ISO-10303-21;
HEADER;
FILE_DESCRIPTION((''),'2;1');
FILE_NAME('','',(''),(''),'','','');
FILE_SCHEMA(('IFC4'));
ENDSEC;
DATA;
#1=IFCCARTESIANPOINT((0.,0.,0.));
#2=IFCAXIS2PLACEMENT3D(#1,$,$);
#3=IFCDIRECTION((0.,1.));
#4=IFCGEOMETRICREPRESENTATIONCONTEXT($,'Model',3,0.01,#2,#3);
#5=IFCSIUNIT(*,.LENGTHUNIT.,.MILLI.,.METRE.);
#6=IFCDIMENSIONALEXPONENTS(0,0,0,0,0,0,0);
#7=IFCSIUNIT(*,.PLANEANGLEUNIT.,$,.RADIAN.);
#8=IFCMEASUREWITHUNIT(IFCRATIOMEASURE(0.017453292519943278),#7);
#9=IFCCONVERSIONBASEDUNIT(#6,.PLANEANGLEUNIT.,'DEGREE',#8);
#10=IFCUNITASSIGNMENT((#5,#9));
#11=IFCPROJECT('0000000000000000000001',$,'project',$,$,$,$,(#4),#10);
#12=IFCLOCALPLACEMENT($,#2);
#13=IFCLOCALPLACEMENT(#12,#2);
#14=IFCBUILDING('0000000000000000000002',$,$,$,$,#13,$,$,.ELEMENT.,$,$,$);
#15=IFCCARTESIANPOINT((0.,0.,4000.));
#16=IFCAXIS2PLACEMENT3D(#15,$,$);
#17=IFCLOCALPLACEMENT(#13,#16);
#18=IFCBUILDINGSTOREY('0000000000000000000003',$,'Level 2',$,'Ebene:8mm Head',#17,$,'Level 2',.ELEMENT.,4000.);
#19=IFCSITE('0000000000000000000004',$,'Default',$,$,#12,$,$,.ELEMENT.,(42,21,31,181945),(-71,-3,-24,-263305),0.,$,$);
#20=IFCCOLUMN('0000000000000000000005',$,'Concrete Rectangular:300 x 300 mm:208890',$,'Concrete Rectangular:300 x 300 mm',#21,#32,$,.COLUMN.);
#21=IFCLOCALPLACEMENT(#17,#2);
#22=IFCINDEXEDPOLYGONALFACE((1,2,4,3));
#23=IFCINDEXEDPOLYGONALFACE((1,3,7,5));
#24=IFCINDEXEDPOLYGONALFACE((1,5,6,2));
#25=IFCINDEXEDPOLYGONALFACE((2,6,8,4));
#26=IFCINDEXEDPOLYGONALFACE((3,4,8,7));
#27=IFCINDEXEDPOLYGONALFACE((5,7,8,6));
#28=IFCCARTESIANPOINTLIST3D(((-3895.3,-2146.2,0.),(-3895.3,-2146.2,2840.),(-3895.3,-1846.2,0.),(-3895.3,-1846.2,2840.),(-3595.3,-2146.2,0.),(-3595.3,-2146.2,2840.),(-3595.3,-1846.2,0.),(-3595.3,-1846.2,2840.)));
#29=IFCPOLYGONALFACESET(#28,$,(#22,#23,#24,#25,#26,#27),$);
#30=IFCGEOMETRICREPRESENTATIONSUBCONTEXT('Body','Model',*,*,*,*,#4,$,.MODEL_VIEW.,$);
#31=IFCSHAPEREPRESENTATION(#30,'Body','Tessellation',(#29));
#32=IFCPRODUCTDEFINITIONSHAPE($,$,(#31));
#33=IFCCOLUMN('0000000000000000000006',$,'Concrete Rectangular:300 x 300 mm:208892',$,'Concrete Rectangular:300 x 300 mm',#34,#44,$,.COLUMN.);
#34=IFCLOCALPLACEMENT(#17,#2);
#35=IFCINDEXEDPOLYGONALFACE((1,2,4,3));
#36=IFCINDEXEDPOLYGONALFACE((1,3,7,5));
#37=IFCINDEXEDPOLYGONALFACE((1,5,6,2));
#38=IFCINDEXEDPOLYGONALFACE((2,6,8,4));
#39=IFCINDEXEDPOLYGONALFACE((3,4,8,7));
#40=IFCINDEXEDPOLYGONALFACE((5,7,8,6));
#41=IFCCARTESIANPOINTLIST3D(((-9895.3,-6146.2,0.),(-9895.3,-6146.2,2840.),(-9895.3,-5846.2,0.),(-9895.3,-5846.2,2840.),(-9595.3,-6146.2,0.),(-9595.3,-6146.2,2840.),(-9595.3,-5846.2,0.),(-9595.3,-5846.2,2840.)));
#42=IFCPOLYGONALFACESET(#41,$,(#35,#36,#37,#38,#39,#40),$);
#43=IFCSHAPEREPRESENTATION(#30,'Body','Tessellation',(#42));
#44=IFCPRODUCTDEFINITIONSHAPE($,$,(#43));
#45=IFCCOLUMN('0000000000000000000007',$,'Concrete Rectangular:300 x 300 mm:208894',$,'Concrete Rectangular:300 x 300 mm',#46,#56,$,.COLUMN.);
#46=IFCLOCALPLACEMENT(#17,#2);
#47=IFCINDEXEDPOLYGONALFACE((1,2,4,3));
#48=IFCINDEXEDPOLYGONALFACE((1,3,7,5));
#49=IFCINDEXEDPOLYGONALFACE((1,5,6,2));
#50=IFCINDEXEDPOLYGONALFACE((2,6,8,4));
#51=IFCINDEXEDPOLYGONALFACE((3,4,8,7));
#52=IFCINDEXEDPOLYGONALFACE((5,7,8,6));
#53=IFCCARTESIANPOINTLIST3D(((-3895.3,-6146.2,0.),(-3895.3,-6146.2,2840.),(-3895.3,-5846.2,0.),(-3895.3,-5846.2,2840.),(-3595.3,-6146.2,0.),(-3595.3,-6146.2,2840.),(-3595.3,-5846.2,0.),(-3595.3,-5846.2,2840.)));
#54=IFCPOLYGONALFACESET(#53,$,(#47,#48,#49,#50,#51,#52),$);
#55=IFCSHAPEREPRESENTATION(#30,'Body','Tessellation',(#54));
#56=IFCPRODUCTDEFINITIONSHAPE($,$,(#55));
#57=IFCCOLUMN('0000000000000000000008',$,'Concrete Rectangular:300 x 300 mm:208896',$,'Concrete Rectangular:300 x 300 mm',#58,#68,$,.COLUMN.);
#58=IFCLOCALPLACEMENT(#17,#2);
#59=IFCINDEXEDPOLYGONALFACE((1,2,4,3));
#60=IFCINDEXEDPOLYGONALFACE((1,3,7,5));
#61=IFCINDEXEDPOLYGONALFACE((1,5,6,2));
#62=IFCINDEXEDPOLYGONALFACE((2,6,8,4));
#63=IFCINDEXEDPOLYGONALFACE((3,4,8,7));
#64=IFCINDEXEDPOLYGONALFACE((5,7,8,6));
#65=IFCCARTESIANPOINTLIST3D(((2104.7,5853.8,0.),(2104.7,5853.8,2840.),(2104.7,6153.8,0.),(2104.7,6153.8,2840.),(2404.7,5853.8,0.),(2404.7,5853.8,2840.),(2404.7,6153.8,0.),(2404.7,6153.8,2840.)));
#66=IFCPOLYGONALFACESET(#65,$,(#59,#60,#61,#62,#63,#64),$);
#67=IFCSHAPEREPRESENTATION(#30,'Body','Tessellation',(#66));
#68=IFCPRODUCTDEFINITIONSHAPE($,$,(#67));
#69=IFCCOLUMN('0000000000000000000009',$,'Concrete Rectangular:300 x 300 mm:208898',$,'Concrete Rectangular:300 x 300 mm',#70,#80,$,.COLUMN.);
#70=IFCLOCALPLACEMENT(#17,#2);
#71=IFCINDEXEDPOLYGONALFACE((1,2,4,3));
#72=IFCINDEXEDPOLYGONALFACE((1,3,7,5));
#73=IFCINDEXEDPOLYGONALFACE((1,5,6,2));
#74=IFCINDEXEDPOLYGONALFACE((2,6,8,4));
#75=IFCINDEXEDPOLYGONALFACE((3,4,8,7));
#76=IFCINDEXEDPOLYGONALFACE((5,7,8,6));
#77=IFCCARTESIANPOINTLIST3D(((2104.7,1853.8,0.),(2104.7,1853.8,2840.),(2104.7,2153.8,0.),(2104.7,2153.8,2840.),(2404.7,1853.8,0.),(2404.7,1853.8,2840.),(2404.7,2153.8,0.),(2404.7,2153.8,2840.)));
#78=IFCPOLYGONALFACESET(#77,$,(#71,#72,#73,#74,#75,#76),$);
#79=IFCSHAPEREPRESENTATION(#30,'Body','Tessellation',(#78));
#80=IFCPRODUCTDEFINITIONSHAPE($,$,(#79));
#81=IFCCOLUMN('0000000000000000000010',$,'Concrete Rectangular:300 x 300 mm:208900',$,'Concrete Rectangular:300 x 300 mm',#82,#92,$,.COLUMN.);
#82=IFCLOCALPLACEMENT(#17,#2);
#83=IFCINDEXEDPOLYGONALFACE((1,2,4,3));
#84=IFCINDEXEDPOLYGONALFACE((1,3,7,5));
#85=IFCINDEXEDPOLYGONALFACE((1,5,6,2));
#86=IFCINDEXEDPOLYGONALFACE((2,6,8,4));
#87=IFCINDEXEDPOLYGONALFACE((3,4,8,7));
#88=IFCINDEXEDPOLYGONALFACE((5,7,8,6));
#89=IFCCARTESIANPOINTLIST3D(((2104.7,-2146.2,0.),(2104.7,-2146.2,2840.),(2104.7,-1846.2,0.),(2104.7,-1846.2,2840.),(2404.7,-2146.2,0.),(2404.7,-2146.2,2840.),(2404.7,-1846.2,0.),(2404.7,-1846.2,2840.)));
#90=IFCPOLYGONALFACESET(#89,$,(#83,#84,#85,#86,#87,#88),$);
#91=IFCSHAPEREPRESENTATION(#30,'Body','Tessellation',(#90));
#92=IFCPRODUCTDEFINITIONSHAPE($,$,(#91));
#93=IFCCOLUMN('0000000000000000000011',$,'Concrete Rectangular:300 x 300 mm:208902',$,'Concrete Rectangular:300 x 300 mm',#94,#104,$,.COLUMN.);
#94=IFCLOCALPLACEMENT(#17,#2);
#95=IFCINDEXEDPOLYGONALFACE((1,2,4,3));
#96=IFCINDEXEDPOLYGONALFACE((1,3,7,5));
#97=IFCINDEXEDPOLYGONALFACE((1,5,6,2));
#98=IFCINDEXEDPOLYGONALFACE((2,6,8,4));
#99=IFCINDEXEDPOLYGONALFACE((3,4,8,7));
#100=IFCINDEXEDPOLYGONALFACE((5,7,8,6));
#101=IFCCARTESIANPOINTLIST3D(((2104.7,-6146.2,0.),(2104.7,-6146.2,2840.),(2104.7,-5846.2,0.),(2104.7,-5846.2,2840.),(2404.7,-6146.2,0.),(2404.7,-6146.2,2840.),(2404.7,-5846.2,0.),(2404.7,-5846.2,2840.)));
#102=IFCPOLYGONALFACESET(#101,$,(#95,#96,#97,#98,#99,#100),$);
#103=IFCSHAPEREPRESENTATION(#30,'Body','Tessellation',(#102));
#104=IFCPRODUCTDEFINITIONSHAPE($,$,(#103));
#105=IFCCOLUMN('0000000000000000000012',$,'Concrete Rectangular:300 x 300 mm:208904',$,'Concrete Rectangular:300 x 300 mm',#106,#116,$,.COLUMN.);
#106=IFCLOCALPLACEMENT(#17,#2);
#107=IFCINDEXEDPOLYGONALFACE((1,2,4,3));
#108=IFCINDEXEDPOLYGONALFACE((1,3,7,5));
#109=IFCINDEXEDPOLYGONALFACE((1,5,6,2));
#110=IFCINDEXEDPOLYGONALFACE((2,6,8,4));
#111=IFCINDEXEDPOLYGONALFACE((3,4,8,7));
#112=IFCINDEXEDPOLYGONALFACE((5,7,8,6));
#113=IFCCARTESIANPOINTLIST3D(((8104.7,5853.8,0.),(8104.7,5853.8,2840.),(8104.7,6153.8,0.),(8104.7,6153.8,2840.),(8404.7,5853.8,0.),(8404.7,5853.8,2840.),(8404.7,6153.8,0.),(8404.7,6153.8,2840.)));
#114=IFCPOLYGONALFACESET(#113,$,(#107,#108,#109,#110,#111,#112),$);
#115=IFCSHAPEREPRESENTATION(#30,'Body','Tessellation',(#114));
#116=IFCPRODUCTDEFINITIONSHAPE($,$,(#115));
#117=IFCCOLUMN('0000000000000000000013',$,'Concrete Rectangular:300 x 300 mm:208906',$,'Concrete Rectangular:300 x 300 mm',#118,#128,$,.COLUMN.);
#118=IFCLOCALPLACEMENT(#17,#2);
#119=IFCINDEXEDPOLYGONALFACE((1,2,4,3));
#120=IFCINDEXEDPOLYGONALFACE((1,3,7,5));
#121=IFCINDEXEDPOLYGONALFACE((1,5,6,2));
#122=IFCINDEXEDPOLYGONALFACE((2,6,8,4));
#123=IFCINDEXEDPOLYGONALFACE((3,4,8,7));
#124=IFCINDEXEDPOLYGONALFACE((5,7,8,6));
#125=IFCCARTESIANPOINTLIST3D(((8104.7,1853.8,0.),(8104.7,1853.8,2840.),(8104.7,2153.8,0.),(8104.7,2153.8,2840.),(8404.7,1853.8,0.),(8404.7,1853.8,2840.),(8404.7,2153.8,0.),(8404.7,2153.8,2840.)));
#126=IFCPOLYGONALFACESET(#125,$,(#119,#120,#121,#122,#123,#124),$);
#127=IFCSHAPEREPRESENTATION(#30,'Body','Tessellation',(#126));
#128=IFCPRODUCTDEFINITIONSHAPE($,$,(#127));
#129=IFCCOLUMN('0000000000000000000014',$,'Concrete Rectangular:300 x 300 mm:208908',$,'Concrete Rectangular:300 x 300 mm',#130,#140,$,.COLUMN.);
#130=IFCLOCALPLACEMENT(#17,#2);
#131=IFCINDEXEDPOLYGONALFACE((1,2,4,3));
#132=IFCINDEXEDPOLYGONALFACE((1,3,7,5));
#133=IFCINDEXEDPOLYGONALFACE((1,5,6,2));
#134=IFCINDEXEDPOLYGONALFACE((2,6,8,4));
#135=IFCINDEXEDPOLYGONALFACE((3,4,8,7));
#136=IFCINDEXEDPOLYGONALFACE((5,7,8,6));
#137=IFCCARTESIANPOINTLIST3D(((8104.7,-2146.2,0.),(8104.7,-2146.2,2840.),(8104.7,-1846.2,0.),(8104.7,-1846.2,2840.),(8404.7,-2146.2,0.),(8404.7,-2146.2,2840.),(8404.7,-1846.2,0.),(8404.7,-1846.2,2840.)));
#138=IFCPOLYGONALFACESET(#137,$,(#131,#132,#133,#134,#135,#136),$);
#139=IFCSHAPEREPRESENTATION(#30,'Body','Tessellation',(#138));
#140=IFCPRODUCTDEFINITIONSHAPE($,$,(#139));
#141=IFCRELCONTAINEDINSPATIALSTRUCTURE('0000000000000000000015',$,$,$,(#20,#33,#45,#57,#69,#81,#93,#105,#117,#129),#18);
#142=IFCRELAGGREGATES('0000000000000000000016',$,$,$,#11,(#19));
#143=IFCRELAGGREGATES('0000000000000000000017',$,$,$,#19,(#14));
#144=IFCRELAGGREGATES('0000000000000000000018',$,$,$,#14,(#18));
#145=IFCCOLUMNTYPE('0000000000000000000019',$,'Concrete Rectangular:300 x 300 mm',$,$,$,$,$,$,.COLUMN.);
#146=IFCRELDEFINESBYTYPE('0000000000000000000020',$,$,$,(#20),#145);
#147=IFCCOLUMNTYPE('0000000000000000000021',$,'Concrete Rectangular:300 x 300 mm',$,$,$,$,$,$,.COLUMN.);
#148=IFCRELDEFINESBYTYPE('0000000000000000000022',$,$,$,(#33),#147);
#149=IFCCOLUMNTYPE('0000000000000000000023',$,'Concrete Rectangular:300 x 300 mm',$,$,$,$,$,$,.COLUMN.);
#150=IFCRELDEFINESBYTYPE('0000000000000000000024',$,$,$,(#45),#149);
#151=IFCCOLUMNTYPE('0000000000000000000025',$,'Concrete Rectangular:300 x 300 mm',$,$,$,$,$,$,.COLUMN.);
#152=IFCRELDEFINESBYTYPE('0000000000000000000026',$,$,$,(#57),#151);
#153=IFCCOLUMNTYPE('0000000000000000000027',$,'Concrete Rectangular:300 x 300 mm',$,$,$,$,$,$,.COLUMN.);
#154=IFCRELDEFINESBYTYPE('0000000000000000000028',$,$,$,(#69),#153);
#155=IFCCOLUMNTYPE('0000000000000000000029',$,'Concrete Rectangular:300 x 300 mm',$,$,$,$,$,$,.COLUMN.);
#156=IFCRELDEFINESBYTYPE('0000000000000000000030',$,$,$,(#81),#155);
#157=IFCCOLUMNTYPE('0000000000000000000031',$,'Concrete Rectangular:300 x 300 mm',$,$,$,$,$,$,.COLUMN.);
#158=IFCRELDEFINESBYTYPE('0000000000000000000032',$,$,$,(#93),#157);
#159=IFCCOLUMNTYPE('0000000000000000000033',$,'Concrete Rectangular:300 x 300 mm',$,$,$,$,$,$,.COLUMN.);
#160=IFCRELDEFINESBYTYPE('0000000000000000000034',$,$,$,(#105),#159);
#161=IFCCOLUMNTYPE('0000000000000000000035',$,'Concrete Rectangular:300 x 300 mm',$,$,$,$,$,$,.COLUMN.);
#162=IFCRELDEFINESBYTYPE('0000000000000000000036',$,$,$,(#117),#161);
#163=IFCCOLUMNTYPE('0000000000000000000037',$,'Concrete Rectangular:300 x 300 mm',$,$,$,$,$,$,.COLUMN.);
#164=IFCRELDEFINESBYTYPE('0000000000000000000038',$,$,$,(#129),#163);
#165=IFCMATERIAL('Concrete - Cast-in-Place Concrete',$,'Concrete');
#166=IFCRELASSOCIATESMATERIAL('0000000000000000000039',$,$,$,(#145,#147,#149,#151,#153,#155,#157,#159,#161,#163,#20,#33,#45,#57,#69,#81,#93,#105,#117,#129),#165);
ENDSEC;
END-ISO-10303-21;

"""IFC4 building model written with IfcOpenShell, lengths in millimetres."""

from ifc_helpers import new_model, entity, si_unit, converted_unit, direction, frame, frame_2d, origin, origin_2d_with_axis, place, context, subcontext, project, spatial, polyline, segment, composite_curve, rectangle, outline, extrude, source, transform, mapped, material, material_profile, profile_set, profile_usage, type_object, type_shapes, element, save


model = new_model("IFC4")

# Units and contexts
model_context = context("Model", 3, precision=0.01, world=origin(), true_north=direction((0.0, 1.0)))
body_context = subcontext(model_context, "Body", "Model", "MODEL_VIEW")
ifc_project = project(units=[si_unit("LENGTHUNIT", "METRE", prefix="MILLI"), converted_unit("PLANEANGLEUNIT", "DEGREE", entity("IfcRatioMeasure", 0.017453292519943278), si_unit("PLANEANGLEUNIT", "RADIAN"), dimensions=[0, 0, 0, 0, 0, 0, 0])], contexts=[model_context])

# Site, building, storey
site_placement = place(None, origin())
site = spatial("IfcSite", under=ifc_project, at=site_placement, Name="Default", CompositionType="ELEMENT", RefLatitude=(42, 21, 31, 181945), RefLongitude=(-71, -3, -24, -263305), RefElevation=0.0)
building_placement = place(site_placement, origin())
building = spatial("IfcBuilding", under=site, at=building_placement, CompositionType="ELEMENT")
storey_placement = place(building_placement, frame((0.0, 0.0, 4000.0)))
storey = spatial("IfcBuildingStorey", under=building, at=storey_placement, Name="Level 2", ObjectType="Ebene:8mm Head", LongName="Level 2", CompositionType="ELEMENT", Elevation=4000.0)

# Columns
ifc_material_1 = material(Name="Concrete - Cast-in-Place Concrete", Category="Concrete")
ifc_material_profile_1 = material_profile(ifc_material_1, outline(composite_curve([segment(polyline([(150.0, 150.0, 0.0), (150.0, -150.0, 0.0)]), True, "CONTINUOUS"), segment(polyline([(150.0, -150.0, 0.0), (-150.0, -150.0, 0.0)]), True, "CONTINUOUS"), segment(polyline([(-150.0, -150.0, 0.0), (-150.0, 150.0, 0.0)]), True, "CONTINUOUS"), segment(polyline([(-150.0, 150.0, 0.0), (150.0, 150.0, 0.0)]), True, "CONTINUOUS")], self_intersect=False), kind="CURVE"), Name="300 x 300 mm")
ifc_material_profile_2 = material_profile(ifc_material_1, outline(composite_curve([segment(polyline([(150.0, 150.0, 4000.0), (-150.0, 150.0, 4000.0)]), True, "CONTINUOUS"), segment(polyline([(-150.0, 150.0, 4000.0), (-150.0, -150.0, 4000.0)]), True, "CONTINUOUS"), segment(polyline([(-150.0, -150.0, 4000.0), (150.0, -150.0, 4000.0)]), True, "CONTINUOUS"), segment(polyline([(150.0, -150.0, 4000.0), (150.0, 150.0, 4000.0)]), True, "CONTINUOUS")], self_intersect=False), kind="CURVE"), Name="300 x 300 mm")
ifc_profile_set = profile_set([ifc_material_profile_1, ifc_material_profile_2], Name="300 x 300 mm")
ifc_profile_usage_1 = profile_usage(ifc_profile_set)
column_type_1 = type_object("IfcColumnType", Name="Concrete Rectangular:300 x 300 mm", PredefinedType="COLUMN", material=ifc_profile_set)
shared_shape_1 = source(origin(), body_context, "Body", "SweptSolid", [
    extrude(rectangle(XDim=300.0, YDim=300.0, at=origin_2d_with_axis()), frame((-3745.3, -1996.2, 4000.0), z_axis=(0.0, 0.0, 1.0), x_axis=(0.0, -1.0, 0.0)), (0.0, 0.0, 1.0), 2840.0),
])
type_shapes(column_type_1, [shared_shape_1])
column_1_placement = place(storey_placement, frame((0.0, 0.0, -4000.0)))
element("IfcColumn", 1, at=column_1_placement, inside=storey, type_object=column_type_1, material=ifc_profile_usage_1, Name="Concrete Rectangular:300 x 300 mm:208890", ObjectType="Concrete Rectangular:300 x 300 mm", PredefinedType="COLUMN", context=body_context, shape_type="MappedRepresentation", body=[
    mapped(shared_shape_1, transform((0.0, 0.0, 0.0), scale=1.0)),
])
ifc_profile_usage_2 = profile_usage(ifc_profile_set)
column_type_2 = type_object("IfcColumnType", Name="Concrete Rectangular:300 x 300 mm", PredefinedType="COLUMN", material=ifc_profile_set)
shared_shape_2 = source(origin(), body_context, "Body", "SweptSolid", [
    extrude(rectangle(XDim=300.0, YDim=300.0, at=frame_2d((0.0, 0.0), x_axis=(1.0, 0.0))), frame((-9745.3, -5996.2, 4000.0), z_axis=(0.0, 0.0, 1.0), x_axis=(0.0, -1.0, 0.0)), (0.0, 0.0, 1.0), 2840.0),
])
type_shapes(column_type_2, [shared_shape_2])
column_2_placement = place(storey_placement, frame((0.0, 0.0, -4000.0)))
element("IfcColumn", 2, at=column_2_placement, inside=storey, type_object=column_type_2, material=ifc_profile_usage_2, Name="Concrete Rectangular:300 x 300 mm:208892", ObjectType="Concrete Rectangular:300 x 300 mm", PredefinedType="COLUMN", context=body_context, shape_type="MappedRepresentation", body=[
    mapped(shared_shape_2, transform((0.0, 0.0, 0.0), scale=1.0)),
])
ifc_profile_usage_3 = profile_usage(ifc_profile_set)
column_type_3 = type_object("IfcColumnType", Name="Concrete Rectangular:300 x 300 mm", PredefinedType="COLUMN", material=ifc_profile_set)
shared_shape_3 = source(origin(), body_context, "Body", "SweptSolid", [
    extrude(rectangle(XDim=300.0, YDim=300.0, at=frame_2d((0.0, 0.0), x_axis=(1.0, 0.0))), frame((-3745.3, -5996.2, 4000.0), z_axis=(0.0, 0.0, 1.0), x_axis=(0.0, -1.0, 0.0)), (0.0, 0.0, 1.0), 2840.0),
])
type_shapes(column_type_3, [shared_shape_3])
column_3_placement = place(storey_placement, frame((0.0, 0.0, -4000.0)))
element("IfcColumn", 3, at=column_3_placement, inside=storey, type_object=column_type_3, material=ifc_profile_usage_3, Name="Concrete Rectangular:300 x 300 mm:208894", ObjectType="Concrete Rectangular:300 x 300 mm", PredefinedType="COLUMN", context=body_context, shape_type="MappedRepresentation", body=[
    mapped(shared_shape_3, transform((0.0, 0.0, 0.0), scale=1.0)),
])
ifc_profile_usage_4 = profile_usage(ifc_profile_set)
column_type_4 = type_object("IfcColumnType", Name="Concrete Rectangular:300 x 300 mm", PredefinedType="COLUMN", material=ifc_profile_set)
shared_shape_4 = source(origin(), body_context, "Body", "SweptSolid", [
    extrude(rectangle(XDim=300.0, YDim=300.0, at=frame_2d((0.0, 0.0), x_axis=(1.0, 0.0))), frame((2254.7, 6003.8, 4000.0), z_axis=(0.0, 0.0, 1.0), x_axis=(0.0, -1.0, 0.0)), (0.0, 0.0, 1.0), 2840.0),
])
type_shapes(column_type_4, [shared_shape_4])
column_4_placement = place(storey_placement, frame((0.0, 0.0, -4000.0)))
element("IfcColumn", 4, at=column_4_placement, inside=storey, type_object=column_type_4, material=ifc_profile_usage_4, Name="Concrete Rectangular:300 x 300 mm:208896", ObjectType="Concrete Rectangular:300 x 300 mm", PredefinedType="COLUMN", context=body_context, shape_type="MappedRepresentation", body=[
    mapped(shared_shape_4, transform((0.0, 0.0, 0.0), scale=1.0)),
])
ifc_profile_usage_5 = profile_usage(ifc_profile_set)
column_type_5 = type_object("IfcColumnType", Name="Concrete Rectangular:300 x 300 mm", PredefinedType="COLUMN", material=ifc_profile_set)
shared_shape_5 = source(origin(), body_context, "Body", "SweptSolid", [
    extrude(rectangle(XDim=300.0, YDim=300.0, at=origin_2d_with_axis()), frame((2254.7, 2003.8, 4000.0), z_axis=(0.0, 0.0, 1.0), x_axis=(0.0, -1.0, 0.0)), (0.0, 0.0, 1.0), 2840.0),
])
type_shapes(column_type_5, [shared_shape_5])
column_5_placement = place(storey_placement, frame((0.0, 0.0, -4000.0)))
element("IfcColumn", 5, at=column_5_placement, inside=storey, type_object=column_type_5, material=ifc_profile_usage_5, Name="Concrete Rectangular:300 x 300 mm:208898", ObjectType="Concrete Rectangular:300 x 300 mm", PredefinedType="COLUMN", context=body_context, shape_type="MappedRepresentation", body=[
    mapped(shared_shape_5, transform((0.0, 0.0, 0.0), scale=1.0)),
])
ifc_profile_usage_6 = profile_usage(ifc_profile_set)
column_type_6 = type_object("IfcColumnType", Name="Concrete Rectangular:300 x 300 mm", PredefinedType="COLUMN", material=ifc_profile_set)
shared_shape_6 = source(origin(), body_context, "Body", "SweptSolid", [
    extrude(rectangle(XDim=300.0, YDim=300.0, at=origin_2d_with_axis()), frame((2254.7, -1996.2, 4000.0), z_axis=(0.0, 0.0, 1.0), x_axis=(0.0, -1.0, 0.0)), (0.0, 0.0, 1.0), 2840.0),
])
type_shapes(column_type_6, [shared_shape_6])
column_6_placement = place(storey_placement, frame((0.0, 0.0, -4000.0)))
element("IfcColumn", 6, at=column_6_placement, inside=storey, type_object=column_type_6, material=ifc_profile_usage_6, Name="Concrete Rectangular:300 x 300 mm:208900", ObjectType="Concrete Rectangular:300 x 300 mm", PredefinedType="COLUMN", context=body_context, shape_type="MappedRepresentation", body=[
    mapped(shared_shape_6, transform((0.0, 0.0, 0.0), scale=1.0)),
])
ifc_profile_usage_7 = profile_usage(ifc_profile_set)
column_type_7 = type_object("IfcColumnType", Name="Concrete Rectangular:300 x 300 mm", PredefinedType="COLUMN", material=ifc_profile_set)
shared_shape_7 = source(origin(), body_context, "Body", "SweptSolid", [
    extrude(rectangle(XDim=300.0, YDim=300.0, at=frame_2d((0.0, 0.0), x_axis=(1.0, 0.0))), frame((2254.7, -5996.2, 4000.0), z_axis=(0.0, 0.0, 1.0), x_axis=(0.0, -1.0, 0.0)), (0.0, 0.0, 1.0), 2840.0),
])
type_shapes(column_type_7, [shared_shape_7])
column_7_placement = place(storey_placement, frame((0.0, 0.0, -4000.0)))
element("IfcColumn", 7, at=column_7_placement, inside=storey, type_object=column_type_7, material=ifc_profile_usage_7, Name="Concrete Rectangular:300 x 300 mm:208902", ObjectType="Concrete Rectangular:300 x 300 mm", PredefinedType="COLUMN", context=body_context, shape_type="MappedRepresentation", body=[
    mapped(shared_shape_7, transform((0.0, 0.0, 0.0), scale=1.0)),
])
ifc_profile_usage_8 = profile_usage(ifc_profile_set)
column_type_8 = type_object("IfcColumnType", Name="Concrete Rectangular:300 x 300 mm", PredefinedType="COLUMN", material=ifc_profile_set)
shared_shape_8 = source(origin(), body_context, "Body", "SweptSolid", [
    extrude(rectangle(XDim=300.0, YDim=300.0, at=frame_2d((0.0, 0.0), x_axis=(1.0, 0.0))), frame((8254.7, 6003.8, 4000.0), z_axis=(0.0, 0.0, 1.0), x_axis=(0.0, -1.0, 0.0)), (0.0, 0.0, 1.0), 2840.0),
])
type_shapes(column_type_8, [shared_shape_8])
column_8_placement = place(storey_placement, frame((0.0, 0.0, -4000.0)))
element("IfcColumn", 8, at=column_8_placement, inside=storey, type_object=column_type_8, material=ifc_profile_usage_8, Name="Concrete Rectangular:300 x 300 mm:208904", ObjectType="Concrete Rectangular:300 x 300 mm", PredefinedType="COLUMN", context=body_context, shape_type="MappedRepresentation", body=[
    mapped(shared_shape_8, transform((0.0, 0.0, 0.0), scale=1.0)),
])
ifc_profile_usage_9 = profile_usage(ifc_profile_set)
column_type_9 = type_object("IfcColumnType", Name="Concrete Rectangular:300 x 300 mm", PredefinedType="COLUMN", material=ifc_profile_set)
shared_shape_9 = source(origin(), body_context, "Body", "SweptSolid", [
    extrude(rectangle(XDim=300.0, YDim=300.0, at=frame_2d((0.0, 0.0), x_axis=(1.0, 0.0))), frame((8254.7, 2003.8, 4000.0), z_axis=(0.0, 0.0, 1.0), x_axis=(0.0, -1.0, 0.0)), (0.0, 0.0, 1.0), 2840.0),
])
type_shapes(column_type_9, [shared_shape_9])
column_9_placement = place(storey_placement, frame((0.0, 0.0, -4000.0)))
element("IfcColumn", 9, at=column_9_placement, inside=storey, type_object=column_type_9, material=ifc_profile_usage_9, Name="Concrete Rectangular:300 x 300 mm:208906", ObjectType="Concrete Rectangular:300 x 300 mm", PredefinedType="COLUMN", context=body_context, shape_type="MappedRepresentation", body=[
    mapped(shared_shape_9, transform((0.0, 0.0, 0.0), scale=1.0)),
])
ifc_profile_usage_10 = profile_usage(ifc_profile_set)
column_type_10 = type_object("IfcColumnType", Name="Concrete Rectangular:300 x 300 mm", PredefinedType="COLUMN", material=ifc_profile_set)
shared_shape_10 = source(origin(), body_context, "Body", "SweptSolid", [
    extrude(rectangle(XDim=300.0, YDim=300.0, at=frame_2d((0.0, 0.0), x_axis=(1.0, 0.0))), frame((8254.7, -1996.2, 4000.0), z_axis=(0.0, 0.0, 1.0), x_axis=(0.0, -1.0, 0.0)), (0.0, 0.0, 1.0), 2840.0),
])
type_shapes(column_type_10, [shared_shape_10])
column_10_placement = place(storey_placement, frame((0.0, 0.0, -4000.0)))
element("IfcColumn", 10, at=column_10_placement, inside=storey, type_object=column_type_10, material=ifc_profile_usage_10, Name="Concrete Rectangular:300 x 300 mm:208908", ObjectType="Concrete Rectangular:300 x 300 mm", PredefinedType="COLUMN", context=body_context, shape_type="MappedRepresentation", body=[
    mapped(shared_shape_10, transform((0.0, 0.0, 0.0), scale=1.0)),
])

save(model, "model.ifc")
